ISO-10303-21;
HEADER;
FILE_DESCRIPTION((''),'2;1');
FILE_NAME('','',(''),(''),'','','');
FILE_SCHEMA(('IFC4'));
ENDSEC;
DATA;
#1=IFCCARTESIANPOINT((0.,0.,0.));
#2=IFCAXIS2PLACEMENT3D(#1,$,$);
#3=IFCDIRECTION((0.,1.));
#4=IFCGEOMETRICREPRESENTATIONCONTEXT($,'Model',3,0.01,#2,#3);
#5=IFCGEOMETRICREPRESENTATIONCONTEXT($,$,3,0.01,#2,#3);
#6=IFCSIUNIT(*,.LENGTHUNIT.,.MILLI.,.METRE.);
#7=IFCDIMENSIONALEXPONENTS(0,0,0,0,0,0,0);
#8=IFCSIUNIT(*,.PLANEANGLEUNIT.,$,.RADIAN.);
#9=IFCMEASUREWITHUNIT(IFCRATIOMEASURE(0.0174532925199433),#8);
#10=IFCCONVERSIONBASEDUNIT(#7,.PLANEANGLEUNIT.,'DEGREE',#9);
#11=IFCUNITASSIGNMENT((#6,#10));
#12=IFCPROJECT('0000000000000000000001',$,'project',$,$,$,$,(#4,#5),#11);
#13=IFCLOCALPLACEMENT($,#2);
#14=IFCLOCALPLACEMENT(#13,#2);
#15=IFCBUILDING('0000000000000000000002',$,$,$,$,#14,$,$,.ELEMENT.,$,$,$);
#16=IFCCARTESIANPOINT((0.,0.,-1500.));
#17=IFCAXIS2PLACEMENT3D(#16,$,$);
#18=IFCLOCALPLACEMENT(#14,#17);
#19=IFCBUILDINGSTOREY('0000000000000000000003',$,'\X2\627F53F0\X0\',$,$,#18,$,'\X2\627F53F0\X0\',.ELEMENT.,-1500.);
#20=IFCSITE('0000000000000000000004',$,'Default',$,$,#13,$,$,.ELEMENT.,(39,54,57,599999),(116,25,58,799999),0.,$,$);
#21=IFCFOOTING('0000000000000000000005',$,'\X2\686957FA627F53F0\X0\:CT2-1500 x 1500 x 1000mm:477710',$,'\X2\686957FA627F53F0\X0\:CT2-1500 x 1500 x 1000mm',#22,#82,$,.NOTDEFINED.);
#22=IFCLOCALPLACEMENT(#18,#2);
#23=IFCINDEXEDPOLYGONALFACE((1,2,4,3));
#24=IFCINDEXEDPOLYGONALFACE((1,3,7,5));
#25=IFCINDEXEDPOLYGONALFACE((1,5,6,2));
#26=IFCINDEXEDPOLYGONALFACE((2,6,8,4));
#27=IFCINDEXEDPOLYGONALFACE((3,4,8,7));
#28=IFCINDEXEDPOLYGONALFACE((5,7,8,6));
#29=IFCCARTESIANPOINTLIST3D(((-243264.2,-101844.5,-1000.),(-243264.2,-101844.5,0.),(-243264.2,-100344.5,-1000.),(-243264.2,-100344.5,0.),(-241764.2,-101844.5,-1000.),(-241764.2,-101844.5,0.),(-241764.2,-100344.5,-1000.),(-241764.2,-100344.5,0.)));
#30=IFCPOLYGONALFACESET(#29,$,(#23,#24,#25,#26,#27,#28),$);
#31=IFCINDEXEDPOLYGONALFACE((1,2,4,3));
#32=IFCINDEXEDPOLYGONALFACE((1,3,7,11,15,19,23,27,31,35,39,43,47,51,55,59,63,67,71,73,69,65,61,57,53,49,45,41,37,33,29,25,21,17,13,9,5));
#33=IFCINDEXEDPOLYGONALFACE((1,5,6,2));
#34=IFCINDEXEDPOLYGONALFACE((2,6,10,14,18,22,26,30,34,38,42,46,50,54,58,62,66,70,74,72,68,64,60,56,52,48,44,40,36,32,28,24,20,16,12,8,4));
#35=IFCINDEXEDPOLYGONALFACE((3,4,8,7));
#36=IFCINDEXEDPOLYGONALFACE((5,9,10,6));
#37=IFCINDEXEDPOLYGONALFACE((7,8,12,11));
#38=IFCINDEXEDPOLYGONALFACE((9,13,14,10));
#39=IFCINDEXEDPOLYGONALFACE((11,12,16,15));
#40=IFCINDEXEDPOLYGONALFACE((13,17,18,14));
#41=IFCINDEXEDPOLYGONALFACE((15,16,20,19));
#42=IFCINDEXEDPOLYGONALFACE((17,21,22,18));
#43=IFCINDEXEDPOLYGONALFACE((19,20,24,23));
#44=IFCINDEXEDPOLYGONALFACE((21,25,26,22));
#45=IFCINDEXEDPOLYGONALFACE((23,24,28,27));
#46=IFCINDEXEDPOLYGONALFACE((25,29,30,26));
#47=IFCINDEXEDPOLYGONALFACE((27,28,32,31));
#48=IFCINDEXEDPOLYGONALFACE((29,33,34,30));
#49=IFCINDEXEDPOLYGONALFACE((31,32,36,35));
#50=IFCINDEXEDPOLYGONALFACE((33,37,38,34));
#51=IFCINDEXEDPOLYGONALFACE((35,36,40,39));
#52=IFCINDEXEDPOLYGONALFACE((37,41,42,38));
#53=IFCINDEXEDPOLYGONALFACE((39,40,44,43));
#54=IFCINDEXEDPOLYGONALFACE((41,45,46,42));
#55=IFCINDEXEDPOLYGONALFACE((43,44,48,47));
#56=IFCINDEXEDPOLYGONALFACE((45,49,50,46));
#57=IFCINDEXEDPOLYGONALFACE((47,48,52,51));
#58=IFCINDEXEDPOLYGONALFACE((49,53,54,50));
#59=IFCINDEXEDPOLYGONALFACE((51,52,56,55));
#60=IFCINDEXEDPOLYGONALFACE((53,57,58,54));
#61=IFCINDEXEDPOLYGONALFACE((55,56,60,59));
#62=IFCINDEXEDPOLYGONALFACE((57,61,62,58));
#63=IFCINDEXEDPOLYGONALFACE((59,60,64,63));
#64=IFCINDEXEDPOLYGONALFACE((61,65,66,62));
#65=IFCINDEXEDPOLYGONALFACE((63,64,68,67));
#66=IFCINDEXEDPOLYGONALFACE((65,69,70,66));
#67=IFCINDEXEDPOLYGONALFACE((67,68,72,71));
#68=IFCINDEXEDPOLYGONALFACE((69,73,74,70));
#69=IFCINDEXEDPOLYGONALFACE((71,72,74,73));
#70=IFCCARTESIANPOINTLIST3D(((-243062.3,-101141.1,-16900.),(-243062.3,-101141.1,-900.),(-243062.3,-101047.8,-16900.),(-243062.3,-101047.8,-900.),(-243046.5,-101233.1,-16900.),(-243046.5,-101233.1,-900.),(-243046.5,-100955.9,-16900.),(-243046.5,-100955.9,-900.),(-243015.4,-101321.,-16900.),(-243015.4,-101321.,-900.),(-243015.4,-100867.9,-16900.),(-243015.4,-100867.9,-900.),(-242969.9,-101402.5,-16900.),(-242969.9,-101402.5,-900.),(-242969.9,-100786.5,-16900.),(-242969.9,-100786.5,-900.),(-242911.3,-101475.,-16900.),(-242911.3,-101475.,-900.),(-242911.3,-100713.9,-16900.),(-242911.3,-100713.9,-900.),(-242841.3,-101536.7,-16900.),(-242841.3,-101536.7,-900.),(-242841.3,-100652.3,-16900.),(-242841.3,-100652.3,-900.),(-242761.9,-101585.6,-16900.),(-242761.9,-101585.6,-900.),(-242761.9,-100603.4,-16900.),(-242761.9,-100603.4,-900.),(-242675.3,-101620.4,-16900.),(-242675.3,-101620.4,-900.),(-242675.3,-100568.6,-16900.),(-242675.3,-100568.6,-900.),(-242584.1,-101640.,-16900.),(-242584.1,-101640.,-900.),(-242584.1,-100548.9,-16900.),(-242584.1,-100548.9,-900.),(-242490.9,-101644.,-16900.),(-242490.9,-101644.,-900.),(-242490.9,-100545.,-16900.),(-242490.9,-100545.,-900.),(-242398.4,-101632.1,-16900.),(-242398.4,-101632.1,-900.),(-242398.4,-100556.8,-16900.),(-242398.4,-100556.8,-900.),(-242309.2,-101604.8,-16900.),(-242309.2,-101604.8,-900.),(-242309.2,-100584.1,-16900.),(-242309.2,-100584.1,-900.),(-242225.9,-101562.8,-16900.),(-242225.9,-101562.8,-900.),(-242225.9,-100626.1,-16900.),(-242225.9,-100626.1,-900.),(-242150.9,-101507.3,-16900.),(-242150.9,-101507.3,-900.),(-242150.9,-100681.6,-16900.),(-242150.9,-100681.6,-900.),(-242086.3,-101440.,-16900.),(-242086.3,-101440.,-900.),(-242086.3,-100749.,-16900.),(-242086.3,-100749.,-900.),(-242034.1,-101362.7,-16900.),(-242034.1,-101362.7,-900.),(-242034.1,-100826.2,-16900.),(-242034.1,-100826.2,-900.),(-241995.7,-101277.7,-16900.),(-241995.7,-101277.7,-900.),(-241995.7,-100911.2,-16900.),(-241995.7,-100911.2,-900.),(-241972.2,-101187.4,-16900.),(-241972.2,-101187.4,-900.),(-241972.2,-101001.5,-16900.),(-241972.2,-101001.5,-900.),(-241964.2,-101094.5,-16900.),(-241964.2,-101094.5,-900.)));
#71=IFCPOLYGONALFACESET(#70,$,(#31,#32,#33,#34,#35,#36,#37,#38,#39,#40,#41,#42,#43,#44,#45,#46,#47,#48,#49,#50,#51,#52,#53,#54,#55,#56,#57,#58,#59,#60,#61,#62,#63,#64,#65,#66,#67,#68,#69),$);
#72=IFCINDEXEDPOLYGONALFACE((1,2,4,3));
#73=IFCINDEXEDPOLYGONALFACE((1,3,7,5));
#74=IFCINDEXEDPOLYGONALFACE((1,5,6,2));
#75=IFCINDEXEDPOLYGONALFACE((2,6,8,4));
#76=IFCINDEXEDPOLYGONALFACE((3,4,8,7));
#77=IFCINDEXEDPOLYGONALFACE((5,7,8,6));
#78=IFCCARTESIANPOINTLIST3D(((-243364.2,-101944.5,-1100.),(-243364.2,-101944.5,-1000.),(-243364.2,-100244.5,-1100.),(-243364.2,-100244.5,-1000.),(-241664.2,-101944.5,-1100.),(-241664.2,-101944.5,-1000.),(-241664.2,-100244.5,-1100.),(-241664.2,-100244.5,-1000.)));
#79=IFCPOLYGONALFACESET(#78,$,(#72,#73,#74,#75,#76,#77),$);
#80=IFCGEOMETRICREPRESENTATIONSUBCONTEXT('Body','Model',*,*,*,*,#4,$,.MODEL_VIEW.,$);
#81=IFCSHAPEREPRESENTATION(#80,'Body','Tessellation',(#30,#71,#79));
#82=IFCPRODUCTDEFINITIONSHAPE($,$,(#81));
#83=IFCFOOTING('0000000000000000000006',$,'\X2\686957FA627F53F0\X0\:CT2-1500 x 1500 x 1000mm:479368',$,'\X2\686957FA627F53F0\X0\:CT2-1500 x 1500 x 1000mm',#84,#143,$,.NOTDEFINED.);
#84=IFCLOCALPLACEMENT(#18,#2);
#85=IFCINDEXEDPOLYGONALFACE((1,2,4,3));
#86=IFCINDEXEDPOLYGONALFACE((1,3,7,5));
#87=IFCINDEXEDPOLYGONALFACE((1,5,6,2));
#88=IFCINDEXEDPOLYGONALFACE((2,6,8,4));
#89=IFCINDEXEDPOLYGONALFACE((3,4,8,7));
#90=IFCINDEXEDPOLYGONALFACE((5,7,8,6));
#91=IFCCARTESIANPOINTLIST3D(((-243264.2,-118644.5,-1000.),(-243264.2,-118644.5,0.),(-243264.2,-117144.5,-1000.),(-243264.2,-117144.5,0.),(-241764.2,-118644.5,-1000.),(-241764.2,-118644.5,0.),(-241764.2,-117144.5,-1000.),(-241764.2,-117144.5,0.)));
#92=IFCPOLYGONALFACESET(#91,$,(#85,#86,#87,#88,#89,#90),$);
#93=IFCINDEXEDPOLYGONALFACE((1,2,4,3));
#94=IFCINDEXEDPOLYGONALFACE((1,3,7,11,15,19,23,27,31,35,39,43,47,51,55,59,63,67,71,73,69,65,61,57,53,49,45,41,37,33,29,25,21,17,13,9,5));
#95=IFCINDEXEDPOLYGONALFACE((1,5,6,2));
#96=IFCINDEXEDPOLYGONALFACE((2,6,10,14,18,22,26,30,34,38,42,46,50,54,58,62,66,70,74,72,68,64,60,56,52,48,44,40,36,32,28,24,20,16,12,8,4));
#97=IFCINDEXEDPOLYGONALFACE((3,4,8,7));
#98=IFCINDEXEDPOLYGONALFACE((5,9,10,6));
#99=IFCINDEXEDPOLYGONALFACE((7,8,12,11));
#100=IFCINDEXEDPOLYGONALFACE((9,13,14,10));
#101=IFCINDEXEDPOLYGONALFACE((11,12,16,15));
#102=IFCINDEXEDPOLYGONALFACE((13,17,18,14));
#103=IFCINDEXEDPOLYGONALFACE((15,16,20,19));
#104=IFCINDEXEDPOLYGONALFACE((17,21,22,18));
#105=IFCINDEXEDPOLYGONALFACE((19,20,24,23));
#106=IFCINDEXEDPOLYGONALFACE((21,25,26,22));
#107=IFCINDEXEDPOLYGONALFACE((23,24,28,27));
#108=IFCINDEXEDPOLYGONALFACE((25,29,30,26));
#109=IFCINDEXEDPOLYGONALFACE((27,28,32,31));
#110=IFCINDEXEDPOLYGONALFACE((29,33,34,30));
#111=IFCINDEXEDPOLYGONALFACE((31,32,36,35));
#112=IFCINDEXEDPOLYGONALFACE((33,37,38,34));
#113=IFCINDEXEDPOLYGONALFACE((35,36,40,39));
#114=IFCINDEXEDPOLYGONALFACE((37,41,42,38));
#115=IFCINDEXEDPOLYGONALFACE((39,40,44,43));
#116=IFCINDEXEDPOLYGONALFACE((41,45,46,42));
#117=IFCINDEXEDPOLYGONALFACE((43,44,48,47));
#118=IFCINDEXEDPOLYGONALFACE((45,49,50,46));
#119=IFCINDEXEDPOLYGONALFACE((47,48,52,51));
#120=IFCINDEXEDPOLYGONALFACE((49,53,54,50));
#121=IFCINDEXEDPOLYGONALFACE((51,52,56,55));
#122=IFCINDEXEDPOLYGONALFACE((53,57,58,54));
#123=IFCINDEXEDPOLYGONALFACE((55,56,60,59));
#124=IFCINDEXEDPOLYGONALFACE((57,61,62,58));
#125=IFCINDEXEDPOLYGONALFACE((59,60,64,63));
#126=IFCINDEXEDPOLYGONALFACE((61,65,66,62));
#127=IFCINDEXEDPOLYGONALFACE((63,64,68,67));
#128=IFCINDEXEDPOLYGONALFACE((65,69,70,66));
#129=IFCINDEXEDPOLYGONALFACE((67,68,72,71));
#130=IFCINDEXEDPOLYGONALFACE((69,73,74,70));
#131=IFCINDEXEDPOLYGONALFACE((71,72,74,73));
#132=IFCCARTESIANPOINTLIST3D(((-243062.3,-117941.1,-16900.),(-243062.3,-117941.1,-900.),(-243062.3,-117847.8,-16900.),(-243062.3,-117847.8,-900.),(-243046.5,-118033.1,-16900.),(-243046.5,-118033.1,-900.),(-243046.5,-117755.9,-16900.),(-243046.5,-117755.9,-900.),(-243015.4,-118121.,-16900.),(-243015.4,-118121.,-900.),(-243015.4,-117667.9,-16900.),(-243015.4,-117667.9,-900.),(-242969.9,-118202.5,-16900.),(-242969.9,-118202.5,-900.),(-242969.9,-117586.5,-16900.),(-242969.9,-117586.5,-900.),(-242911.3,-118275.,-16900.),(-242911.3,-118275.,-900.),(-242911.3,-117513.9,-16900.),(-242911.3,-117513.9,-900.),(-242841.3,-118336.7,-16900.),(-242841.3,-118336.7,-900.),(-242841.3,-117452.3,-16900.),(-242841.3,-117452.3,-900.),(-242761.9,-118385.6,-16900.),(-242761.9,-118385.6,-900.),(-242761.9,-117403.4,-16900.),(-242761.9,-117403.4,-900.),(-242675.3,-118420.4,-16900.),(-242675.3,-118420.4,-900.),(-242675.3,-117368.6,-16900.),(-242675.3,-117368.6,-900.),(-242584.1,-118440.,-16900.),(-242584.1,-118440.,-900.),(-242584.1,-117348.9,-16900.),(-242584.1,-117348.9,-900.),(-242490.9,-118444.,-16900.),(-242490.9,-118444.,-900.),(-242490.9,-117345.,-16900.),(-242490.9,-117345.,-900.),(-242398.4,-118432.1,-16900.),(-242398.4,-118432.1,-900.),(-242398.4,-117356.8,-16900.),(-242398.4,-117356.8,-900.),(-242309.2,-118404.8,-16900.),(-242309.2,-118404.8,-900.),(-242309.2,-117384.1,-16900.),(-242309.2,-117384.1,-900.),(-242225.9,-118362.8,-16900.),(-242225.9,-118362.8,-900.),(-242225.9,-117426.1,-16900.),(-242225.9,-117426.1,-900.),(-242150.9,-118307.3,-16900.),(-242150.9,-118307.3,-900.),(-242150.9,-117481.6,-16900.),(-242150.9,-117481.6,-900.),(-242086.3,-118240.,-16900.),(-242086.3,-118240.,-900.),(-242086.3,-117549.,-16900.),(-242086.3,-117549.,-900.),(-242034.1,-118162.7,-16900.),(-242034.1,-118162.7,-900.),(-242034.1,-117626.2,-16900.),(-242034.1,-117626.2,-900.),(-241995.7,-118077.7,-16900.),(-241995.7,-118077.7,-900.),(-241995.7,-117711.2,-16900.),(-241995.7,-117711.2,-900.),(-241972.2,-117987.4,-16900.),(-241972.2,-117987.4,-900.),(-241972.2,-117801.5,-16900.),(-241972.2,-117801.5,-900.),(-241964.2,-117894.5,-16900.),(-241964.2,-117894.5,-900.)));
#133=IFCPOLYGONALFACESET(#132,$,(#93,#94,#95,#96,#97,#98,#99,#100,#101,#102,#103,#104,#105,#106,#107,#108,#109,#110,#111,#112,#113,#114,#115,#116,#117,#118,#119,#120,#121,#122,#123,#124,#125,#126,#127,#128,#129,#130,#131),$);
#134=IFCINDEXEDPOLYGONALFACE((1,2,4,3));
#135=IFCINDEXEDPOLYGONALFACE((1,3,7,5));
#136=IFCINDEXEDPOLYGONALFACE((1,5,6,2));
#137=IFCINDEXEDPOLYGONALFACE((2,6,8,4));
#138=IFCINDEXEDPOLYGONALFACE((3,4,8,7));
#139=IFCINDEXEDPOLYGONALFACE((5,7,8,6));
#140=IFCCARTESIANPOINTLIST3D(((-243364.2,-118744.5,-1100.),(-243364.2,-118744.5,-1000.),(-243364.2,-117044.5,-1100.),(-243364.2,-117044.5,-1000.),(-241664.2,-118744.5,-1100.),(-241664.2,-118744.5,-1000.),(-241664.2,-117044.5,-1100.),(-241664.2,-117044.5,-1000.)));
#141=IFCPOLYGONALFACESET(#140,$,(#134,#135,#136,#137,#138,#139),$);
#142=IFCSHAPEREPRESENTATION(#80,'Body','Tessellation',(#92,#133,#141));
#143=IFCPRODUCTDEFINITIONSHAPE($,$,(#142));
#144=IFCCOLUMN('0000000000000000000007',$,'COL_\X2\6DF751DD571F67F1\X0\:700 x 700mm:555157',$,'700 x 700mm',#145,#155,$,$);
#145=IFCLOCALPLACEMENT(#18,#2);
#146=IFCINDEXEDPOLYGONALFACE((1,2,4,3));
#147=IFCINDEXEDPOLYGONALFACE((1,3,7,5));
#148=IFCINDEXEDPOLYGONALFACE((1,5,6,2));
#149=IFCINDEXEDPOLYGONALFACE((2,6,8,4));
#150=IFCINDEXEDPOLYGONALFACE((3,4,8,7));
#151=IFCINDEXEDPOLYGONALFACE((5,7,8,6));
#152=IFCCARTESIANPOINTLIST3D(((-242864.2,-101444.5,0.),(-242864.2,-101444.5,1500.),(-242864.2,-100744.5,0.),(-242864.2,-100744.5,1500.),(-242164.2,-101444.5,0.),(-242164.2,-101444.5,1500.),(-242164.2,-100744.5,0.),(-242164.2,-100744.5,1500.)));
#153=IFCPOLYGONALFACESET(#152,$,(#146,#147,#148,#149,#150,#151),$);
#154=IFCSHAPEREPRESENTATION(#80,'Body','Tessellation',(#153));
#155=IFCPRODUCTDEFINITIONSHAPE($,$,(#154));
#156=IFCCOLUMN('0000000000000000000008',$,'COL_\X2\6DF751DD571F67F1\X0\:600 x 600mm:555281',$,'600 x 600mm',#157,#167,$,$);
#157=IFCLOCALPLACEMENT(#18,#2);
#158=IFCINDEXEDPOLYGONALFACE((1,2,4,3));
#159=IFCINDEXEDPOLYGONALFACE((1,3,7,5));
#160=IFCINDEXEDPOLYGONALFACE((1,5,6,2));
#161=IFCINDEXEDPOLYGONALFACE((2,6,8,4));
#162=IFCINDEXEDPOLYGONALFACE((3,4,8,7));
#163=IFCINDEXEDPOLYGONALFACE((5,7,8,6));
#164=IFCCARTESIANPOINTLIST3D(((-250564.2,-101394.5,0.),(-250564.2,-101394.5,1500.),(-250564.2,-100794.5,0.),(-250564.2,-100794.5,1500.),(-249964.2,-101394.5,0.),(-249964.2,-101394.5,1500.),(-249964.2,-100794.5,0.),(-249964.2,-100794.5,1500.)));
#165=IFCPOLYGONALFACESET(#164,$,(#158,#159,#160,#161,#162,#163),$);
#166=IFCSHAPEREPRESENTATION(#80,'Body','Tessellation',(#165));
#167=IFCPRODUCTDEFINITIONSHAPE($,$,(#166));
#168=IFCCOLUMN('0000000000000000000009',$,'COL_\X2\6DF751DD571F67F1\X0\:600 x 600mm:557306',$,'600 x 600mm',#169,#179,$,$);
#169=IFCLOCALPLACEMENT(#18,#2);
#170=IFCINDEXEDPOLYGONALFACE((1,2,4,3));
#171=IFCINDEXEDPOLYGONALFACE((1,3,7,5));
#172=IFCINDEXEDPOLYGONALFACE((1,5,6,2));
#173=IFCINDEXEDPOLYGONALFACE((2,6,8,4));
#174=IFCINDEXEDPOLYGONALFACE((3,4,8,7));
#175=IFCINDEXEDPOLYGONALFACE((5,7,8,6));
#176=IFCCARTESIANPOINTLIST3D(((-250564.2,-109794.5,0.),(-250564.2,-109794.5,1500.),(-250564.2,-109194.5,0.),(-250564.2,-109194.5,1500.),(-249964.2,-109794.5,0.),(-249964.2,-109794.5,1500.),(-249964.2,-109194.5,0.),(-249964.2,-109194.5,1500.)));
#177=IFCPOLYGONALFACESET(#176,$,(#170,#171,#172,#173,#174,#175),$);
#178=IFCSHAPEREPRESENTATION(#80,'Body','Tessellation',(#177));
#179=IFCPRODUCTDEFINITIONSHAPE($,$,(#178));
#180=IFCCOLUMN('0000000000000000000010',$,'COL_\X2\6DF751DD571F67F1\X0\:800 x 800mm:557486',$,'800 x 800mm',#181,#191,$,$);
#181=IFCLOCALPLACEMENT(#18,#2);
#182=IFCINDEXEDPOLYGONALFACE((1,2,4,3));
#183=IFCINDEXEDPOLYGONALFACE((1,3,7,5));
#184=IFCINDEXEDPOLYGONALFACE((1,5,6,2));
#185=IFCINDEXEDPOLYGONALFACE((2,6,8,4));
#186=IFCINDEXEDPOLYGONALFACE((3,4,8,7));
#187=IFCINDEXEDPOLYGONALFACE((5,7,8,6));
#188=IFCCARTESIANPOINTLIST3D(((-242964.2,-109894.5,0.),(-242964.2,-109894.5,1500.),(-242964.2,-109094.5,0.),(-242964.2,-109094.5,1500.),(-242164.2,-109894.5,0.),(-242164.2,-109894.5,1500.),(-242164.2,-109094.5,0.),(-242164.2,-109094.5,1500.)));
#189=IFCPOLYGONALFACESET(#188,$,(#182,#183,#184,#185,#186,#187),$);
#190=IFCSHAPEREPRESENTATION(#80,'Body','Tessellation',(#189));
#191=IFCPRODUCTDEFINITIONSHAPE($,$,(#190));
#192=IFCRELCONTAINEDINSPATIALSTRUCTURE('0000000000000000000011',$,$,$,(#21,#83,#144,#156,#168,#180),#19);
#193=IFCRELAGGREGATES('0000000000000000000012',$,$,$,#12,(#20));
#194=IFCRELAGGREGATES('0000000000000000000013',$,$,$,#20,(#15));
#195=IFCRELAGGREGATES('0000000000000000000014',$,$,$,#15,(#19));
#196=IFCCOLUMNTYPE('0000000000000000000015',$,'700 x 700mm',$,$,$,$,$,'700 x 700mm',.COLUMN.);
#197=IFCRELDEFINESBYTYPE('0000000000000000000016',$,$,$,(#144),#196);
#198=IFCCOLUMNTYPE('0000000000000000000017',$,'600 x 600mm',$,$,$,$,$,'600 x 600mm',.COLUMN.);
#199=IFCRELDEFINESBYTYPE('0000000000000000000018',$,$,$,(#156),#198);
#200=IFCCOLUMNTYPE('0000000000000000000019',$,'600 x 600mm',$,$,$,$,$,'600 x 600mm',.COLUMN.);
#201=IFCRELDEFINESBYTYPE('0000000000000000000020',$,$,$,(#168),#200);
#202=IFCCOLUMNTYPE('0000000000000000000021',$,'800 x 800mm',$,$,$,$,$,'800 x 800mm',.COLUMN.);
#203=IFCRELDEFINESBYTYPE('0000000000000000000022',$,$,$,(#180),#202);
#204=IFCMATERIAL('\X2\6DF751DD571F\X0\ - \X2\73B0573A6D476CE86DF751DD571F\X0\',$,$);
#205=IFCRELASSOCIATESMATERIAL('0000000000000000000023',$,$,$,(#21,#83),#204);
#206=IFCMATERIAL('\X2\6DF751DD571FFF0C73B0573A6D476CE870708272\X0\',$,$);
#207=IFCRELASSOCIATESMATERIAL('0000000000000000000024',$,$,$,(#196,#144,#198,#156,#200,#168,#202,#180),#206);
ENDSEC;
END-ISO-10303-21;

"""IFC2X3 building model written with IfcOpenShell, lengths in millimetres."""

from ifc_helpers import new_model, entity, si_unit, converted_unit, direction, frame, frame_2d, origin, origin_2d_with_axis, place, context, subcontext, project, spatial, rectangle, circle, extrude, source, transform, mapped, material, type_object, type_shapes, element, save


model = new_model("IFC2X3")

# Units and contexts
model_context = context("Model", 3, precision=0.01, world=origin(), true_north=direction((0.0, 1.0)))
context_of_model = context(None, 3, precision=0.01, world=origin(), true_north=direction((0.0, 1.0)))
body_context = subcontext(model_context, "Body", "Model", "MODEL_VIEW")
ifc_project = project(units=[si_unit("LENGTHUNIT", "METRE", prefix="MILLI"), converted_unit("PLANEANGLEUNIT", "DEGREE", entity("IfcRatioMeasure", 0.0174532925199433), si_unit("PLANEANGLEUNIT", "RADIAN"), dimensions=[0, 0, 0, 0, 0, 0, 0])], contexts=[model_context, context_of_model])

# Site, building, storey
site_placement = place(None, origin())
site = spatial("IfcSite", under=ifc_project, at=site_placement, Name="Default", CompositionType="ELEMENT", RefLatitude=(39, 54, 57, 599999), RefLongitude=(116, 25, 58, 799999), RefElevation=0.0)
building_placement = place(site_placement, origin())
building = spatial("IfcBuilding", under=site, at=building_placement, CompositionType="ELEMENT")
storey_placement = place(building_placement, frame((0.0, 0.0, -1500.0)))
storey = spatial("IfcBuildingStorey", under=building, at=storey_placement, Name="承台", LongName="承台", CompositionType="ELEMENT", Elevation=-1500.0)

# Footings
ifc_material_1 = material(Name="混凝土 - 现场浇注混凝土")
for number, where, name in (
    (1, (-243364.2, -101944.5, -16900.0), "桩基承台:CT2-1500 x 1500 x 1000mm:477710"),
    (2, (-243364.2, -118744.5, -16900.0), "桩基承台:CT2-1500 x 1500 x 1000mm:479368"),
):
    element("IfcFooting", number, at=place(storey_placement, frame(where)), inside=storey, material=ifc_material_1, Name=name, ObjectType="桩基承台:CT2-1500 x 1500 x 1000mm", PredefinedType="NOTDEFINED", context=body_context, shape_type="SweptSolid", body=[
        extrude(rectangle(XDim=1500.0, YDim=1500.0, at=origin_2d_with_axis()), frame((850.0, 850.0, 15900.0), z_axis=(0.0, 0.0, 1.0), x_axis=(-1.0, 0.0, 0.0)), (0.0, 0.0, 1.0), 1000.0),
        extrude(circle(Radius=550.0, at=origin_2d_with_axis()), frame((850.0, 850.0, 0.0)), (0.0, 0.0, 1.0), 16000.0),
        extrude(rectangle(XDim=1700.0, YDim=1700.0, at=frame_2d((0.0, 0.0), x_axis=(1.0, 0.0))), frame((850.0, 850.0, 15800.0), z_axis=(0.0, 0.0, 1.0), x_axis=(0.0, 1.0, 0.0)), (0.0, 0.0, 1.0), 100.0),
    ])

# Columns
ifc_material_2 = material(Name="混凝土，现场浇注灰色")
column_type_1 = type_object("IfcColumnType", Name="700 x 700mm", ElementType="700 x 700mm", PredefinedType="COLUMN", material=ifc_material_2)
shared_shape_1 = source(origin(), body_context, "Body", "SweptSolid", [
    extrude(rectangle(XDim=700.0, YDim=700.0, at=frame_2d((0.0, 0.0), x_axis=(1.0, 0.0))), frame((350.0, 350.0, 0.0), z_axis=(0.0, 0.0, 1.0), x_axis=(-1.0, 0.0, 0.0)), (0.0, 0.0, 1.0), 1500.0),
])
type_shapes(column_type_1, [shared_shape_1])
column_1_placement = place(storey_placement, frame((-242864.2, -101444.5, 0.0)))
element("IfcColumn", 3, at=column_1_placement, inside=storey, type_object=column_type_1, material=ifc_material_2, Name="COL_混凝土柱:700 x 700mm:555157", ObjectType="700 x 700mm", context=body_context, shape_type="MappedRepresentation", body=[
    mapped(shared_shape_1, transform((0.0, 0.0, 0.0), scale=1.0)),
])
column_type_2 = type_object("IfcColumnType", Name="600 x 600mm", ElementType="600 x 600mm", PredefinedType="COLUMN", material=ifc_material_2)
shared_shape_2 = source(origin(), body_context, "Body", "SweptSolid", [
    extrude(rectangle(XDim=600.0, YDim=600.0, at=origin_2d_with_axis()), frame((300.0, 300.0, 0.0), z_axis=(0.0, 0.0, 1.0), x_axis=(-1.0, 0.0, 0.0)), (0.0, 0.0, 1.0), 1500.0),
])
type_shapes(column_type_2, [shared_shape_2])
column_2_placement = place(storey_placement, frame((-250564.2, -101394.5, 0.0)))
element("IfcColumn", 4, at=column_2_placement, inside=storey, type_object=column_type_2, material=ifc_material_2, Name="COL_混凝土柱:600 x 600mm:555281", ObjectType="600 x 600mm", context=body_context, shape_type="MappedRepresentation", body=[
    mapped(shared_shape_2, transform((0.0, 0.0, 0.0), scale=1.0)),
])
column_type_3 = type_object("IfcColumnType", Name="600 x 600mm", ElementType="600 x 600mm", PredefinedType="COLUMN", material=ifc_material_2)
shared_shape_3 = source(origin(), body_context, "Body", "SweptSolid", [
    extrude(rectangle(XDim=600.0, YDim=600.0, at=origin_2d_with_axis()), frame((300.0, 300.0, 0.0), z_axis=(0.0, 0.0, 1.0), x_axis=(-1.0, 0.0, 0.0)), (0.0, 0.0, 1.0), 1500.0),
])
type_shapes(column_type_3, [shared_shape_3])
column_3_placement = place(storey_placement, frame((-250564.2, -109794.5, 0.0)))
element("IfcColumn", 5, at=column_3_placement, inside=storey, type_object=column_type_3, material=ifc_material_2, Name="COL_混凝土柱:600 x 600mm:557306", ObjectType="600 x 600mm", context=body_context, shape_type="MappedRepresentation", body=[
    mapped(shared_shape_3, transform((0.0, 0.0, 0.0), scale=1.0)),
])
column_type_4 = type_object("IfcColumnType", Name="800 x 800mm", ElementType="800 x 800mm", PredefinedType="COLUMN", material=ifc_material_2)
shared_shape_4 = source(origin(), body_context, "Body", "SweptSolid", [
    extrude(rectangle(XDim=800.0, YDim=800.0, at=frame_2d((0.0, 0.0), x_axis=(1.0, 0.0))), frame((400.0, 400.0, 0.0), z_axis=(0.0, 0.0, 1.0), x_axis=(-1.0, 0.0, 0.0)), (0.0, 0.0, 1.0), 1500.0),
])
type_shapes(column_type_4, [shared_shape_4])
column_4_placement = place(storey_placement, frame((-242964.2, -109894.5, 0.0)))
element("IfcColumn", 6, at=column_4_placement, inside=storey, type_object=column_type_4, material=ifc_material_2, Name="COL_混凝土柱:800 x 800mm:557486", ObjectType="800 x 800mm", context=body_context, shape_type="MappedRepresentation", body=[
    mapped(shared_shape_4, transform((0.0, 0.0, 0.0), scale=1.0)),
])

save(model, "model.ifc")
